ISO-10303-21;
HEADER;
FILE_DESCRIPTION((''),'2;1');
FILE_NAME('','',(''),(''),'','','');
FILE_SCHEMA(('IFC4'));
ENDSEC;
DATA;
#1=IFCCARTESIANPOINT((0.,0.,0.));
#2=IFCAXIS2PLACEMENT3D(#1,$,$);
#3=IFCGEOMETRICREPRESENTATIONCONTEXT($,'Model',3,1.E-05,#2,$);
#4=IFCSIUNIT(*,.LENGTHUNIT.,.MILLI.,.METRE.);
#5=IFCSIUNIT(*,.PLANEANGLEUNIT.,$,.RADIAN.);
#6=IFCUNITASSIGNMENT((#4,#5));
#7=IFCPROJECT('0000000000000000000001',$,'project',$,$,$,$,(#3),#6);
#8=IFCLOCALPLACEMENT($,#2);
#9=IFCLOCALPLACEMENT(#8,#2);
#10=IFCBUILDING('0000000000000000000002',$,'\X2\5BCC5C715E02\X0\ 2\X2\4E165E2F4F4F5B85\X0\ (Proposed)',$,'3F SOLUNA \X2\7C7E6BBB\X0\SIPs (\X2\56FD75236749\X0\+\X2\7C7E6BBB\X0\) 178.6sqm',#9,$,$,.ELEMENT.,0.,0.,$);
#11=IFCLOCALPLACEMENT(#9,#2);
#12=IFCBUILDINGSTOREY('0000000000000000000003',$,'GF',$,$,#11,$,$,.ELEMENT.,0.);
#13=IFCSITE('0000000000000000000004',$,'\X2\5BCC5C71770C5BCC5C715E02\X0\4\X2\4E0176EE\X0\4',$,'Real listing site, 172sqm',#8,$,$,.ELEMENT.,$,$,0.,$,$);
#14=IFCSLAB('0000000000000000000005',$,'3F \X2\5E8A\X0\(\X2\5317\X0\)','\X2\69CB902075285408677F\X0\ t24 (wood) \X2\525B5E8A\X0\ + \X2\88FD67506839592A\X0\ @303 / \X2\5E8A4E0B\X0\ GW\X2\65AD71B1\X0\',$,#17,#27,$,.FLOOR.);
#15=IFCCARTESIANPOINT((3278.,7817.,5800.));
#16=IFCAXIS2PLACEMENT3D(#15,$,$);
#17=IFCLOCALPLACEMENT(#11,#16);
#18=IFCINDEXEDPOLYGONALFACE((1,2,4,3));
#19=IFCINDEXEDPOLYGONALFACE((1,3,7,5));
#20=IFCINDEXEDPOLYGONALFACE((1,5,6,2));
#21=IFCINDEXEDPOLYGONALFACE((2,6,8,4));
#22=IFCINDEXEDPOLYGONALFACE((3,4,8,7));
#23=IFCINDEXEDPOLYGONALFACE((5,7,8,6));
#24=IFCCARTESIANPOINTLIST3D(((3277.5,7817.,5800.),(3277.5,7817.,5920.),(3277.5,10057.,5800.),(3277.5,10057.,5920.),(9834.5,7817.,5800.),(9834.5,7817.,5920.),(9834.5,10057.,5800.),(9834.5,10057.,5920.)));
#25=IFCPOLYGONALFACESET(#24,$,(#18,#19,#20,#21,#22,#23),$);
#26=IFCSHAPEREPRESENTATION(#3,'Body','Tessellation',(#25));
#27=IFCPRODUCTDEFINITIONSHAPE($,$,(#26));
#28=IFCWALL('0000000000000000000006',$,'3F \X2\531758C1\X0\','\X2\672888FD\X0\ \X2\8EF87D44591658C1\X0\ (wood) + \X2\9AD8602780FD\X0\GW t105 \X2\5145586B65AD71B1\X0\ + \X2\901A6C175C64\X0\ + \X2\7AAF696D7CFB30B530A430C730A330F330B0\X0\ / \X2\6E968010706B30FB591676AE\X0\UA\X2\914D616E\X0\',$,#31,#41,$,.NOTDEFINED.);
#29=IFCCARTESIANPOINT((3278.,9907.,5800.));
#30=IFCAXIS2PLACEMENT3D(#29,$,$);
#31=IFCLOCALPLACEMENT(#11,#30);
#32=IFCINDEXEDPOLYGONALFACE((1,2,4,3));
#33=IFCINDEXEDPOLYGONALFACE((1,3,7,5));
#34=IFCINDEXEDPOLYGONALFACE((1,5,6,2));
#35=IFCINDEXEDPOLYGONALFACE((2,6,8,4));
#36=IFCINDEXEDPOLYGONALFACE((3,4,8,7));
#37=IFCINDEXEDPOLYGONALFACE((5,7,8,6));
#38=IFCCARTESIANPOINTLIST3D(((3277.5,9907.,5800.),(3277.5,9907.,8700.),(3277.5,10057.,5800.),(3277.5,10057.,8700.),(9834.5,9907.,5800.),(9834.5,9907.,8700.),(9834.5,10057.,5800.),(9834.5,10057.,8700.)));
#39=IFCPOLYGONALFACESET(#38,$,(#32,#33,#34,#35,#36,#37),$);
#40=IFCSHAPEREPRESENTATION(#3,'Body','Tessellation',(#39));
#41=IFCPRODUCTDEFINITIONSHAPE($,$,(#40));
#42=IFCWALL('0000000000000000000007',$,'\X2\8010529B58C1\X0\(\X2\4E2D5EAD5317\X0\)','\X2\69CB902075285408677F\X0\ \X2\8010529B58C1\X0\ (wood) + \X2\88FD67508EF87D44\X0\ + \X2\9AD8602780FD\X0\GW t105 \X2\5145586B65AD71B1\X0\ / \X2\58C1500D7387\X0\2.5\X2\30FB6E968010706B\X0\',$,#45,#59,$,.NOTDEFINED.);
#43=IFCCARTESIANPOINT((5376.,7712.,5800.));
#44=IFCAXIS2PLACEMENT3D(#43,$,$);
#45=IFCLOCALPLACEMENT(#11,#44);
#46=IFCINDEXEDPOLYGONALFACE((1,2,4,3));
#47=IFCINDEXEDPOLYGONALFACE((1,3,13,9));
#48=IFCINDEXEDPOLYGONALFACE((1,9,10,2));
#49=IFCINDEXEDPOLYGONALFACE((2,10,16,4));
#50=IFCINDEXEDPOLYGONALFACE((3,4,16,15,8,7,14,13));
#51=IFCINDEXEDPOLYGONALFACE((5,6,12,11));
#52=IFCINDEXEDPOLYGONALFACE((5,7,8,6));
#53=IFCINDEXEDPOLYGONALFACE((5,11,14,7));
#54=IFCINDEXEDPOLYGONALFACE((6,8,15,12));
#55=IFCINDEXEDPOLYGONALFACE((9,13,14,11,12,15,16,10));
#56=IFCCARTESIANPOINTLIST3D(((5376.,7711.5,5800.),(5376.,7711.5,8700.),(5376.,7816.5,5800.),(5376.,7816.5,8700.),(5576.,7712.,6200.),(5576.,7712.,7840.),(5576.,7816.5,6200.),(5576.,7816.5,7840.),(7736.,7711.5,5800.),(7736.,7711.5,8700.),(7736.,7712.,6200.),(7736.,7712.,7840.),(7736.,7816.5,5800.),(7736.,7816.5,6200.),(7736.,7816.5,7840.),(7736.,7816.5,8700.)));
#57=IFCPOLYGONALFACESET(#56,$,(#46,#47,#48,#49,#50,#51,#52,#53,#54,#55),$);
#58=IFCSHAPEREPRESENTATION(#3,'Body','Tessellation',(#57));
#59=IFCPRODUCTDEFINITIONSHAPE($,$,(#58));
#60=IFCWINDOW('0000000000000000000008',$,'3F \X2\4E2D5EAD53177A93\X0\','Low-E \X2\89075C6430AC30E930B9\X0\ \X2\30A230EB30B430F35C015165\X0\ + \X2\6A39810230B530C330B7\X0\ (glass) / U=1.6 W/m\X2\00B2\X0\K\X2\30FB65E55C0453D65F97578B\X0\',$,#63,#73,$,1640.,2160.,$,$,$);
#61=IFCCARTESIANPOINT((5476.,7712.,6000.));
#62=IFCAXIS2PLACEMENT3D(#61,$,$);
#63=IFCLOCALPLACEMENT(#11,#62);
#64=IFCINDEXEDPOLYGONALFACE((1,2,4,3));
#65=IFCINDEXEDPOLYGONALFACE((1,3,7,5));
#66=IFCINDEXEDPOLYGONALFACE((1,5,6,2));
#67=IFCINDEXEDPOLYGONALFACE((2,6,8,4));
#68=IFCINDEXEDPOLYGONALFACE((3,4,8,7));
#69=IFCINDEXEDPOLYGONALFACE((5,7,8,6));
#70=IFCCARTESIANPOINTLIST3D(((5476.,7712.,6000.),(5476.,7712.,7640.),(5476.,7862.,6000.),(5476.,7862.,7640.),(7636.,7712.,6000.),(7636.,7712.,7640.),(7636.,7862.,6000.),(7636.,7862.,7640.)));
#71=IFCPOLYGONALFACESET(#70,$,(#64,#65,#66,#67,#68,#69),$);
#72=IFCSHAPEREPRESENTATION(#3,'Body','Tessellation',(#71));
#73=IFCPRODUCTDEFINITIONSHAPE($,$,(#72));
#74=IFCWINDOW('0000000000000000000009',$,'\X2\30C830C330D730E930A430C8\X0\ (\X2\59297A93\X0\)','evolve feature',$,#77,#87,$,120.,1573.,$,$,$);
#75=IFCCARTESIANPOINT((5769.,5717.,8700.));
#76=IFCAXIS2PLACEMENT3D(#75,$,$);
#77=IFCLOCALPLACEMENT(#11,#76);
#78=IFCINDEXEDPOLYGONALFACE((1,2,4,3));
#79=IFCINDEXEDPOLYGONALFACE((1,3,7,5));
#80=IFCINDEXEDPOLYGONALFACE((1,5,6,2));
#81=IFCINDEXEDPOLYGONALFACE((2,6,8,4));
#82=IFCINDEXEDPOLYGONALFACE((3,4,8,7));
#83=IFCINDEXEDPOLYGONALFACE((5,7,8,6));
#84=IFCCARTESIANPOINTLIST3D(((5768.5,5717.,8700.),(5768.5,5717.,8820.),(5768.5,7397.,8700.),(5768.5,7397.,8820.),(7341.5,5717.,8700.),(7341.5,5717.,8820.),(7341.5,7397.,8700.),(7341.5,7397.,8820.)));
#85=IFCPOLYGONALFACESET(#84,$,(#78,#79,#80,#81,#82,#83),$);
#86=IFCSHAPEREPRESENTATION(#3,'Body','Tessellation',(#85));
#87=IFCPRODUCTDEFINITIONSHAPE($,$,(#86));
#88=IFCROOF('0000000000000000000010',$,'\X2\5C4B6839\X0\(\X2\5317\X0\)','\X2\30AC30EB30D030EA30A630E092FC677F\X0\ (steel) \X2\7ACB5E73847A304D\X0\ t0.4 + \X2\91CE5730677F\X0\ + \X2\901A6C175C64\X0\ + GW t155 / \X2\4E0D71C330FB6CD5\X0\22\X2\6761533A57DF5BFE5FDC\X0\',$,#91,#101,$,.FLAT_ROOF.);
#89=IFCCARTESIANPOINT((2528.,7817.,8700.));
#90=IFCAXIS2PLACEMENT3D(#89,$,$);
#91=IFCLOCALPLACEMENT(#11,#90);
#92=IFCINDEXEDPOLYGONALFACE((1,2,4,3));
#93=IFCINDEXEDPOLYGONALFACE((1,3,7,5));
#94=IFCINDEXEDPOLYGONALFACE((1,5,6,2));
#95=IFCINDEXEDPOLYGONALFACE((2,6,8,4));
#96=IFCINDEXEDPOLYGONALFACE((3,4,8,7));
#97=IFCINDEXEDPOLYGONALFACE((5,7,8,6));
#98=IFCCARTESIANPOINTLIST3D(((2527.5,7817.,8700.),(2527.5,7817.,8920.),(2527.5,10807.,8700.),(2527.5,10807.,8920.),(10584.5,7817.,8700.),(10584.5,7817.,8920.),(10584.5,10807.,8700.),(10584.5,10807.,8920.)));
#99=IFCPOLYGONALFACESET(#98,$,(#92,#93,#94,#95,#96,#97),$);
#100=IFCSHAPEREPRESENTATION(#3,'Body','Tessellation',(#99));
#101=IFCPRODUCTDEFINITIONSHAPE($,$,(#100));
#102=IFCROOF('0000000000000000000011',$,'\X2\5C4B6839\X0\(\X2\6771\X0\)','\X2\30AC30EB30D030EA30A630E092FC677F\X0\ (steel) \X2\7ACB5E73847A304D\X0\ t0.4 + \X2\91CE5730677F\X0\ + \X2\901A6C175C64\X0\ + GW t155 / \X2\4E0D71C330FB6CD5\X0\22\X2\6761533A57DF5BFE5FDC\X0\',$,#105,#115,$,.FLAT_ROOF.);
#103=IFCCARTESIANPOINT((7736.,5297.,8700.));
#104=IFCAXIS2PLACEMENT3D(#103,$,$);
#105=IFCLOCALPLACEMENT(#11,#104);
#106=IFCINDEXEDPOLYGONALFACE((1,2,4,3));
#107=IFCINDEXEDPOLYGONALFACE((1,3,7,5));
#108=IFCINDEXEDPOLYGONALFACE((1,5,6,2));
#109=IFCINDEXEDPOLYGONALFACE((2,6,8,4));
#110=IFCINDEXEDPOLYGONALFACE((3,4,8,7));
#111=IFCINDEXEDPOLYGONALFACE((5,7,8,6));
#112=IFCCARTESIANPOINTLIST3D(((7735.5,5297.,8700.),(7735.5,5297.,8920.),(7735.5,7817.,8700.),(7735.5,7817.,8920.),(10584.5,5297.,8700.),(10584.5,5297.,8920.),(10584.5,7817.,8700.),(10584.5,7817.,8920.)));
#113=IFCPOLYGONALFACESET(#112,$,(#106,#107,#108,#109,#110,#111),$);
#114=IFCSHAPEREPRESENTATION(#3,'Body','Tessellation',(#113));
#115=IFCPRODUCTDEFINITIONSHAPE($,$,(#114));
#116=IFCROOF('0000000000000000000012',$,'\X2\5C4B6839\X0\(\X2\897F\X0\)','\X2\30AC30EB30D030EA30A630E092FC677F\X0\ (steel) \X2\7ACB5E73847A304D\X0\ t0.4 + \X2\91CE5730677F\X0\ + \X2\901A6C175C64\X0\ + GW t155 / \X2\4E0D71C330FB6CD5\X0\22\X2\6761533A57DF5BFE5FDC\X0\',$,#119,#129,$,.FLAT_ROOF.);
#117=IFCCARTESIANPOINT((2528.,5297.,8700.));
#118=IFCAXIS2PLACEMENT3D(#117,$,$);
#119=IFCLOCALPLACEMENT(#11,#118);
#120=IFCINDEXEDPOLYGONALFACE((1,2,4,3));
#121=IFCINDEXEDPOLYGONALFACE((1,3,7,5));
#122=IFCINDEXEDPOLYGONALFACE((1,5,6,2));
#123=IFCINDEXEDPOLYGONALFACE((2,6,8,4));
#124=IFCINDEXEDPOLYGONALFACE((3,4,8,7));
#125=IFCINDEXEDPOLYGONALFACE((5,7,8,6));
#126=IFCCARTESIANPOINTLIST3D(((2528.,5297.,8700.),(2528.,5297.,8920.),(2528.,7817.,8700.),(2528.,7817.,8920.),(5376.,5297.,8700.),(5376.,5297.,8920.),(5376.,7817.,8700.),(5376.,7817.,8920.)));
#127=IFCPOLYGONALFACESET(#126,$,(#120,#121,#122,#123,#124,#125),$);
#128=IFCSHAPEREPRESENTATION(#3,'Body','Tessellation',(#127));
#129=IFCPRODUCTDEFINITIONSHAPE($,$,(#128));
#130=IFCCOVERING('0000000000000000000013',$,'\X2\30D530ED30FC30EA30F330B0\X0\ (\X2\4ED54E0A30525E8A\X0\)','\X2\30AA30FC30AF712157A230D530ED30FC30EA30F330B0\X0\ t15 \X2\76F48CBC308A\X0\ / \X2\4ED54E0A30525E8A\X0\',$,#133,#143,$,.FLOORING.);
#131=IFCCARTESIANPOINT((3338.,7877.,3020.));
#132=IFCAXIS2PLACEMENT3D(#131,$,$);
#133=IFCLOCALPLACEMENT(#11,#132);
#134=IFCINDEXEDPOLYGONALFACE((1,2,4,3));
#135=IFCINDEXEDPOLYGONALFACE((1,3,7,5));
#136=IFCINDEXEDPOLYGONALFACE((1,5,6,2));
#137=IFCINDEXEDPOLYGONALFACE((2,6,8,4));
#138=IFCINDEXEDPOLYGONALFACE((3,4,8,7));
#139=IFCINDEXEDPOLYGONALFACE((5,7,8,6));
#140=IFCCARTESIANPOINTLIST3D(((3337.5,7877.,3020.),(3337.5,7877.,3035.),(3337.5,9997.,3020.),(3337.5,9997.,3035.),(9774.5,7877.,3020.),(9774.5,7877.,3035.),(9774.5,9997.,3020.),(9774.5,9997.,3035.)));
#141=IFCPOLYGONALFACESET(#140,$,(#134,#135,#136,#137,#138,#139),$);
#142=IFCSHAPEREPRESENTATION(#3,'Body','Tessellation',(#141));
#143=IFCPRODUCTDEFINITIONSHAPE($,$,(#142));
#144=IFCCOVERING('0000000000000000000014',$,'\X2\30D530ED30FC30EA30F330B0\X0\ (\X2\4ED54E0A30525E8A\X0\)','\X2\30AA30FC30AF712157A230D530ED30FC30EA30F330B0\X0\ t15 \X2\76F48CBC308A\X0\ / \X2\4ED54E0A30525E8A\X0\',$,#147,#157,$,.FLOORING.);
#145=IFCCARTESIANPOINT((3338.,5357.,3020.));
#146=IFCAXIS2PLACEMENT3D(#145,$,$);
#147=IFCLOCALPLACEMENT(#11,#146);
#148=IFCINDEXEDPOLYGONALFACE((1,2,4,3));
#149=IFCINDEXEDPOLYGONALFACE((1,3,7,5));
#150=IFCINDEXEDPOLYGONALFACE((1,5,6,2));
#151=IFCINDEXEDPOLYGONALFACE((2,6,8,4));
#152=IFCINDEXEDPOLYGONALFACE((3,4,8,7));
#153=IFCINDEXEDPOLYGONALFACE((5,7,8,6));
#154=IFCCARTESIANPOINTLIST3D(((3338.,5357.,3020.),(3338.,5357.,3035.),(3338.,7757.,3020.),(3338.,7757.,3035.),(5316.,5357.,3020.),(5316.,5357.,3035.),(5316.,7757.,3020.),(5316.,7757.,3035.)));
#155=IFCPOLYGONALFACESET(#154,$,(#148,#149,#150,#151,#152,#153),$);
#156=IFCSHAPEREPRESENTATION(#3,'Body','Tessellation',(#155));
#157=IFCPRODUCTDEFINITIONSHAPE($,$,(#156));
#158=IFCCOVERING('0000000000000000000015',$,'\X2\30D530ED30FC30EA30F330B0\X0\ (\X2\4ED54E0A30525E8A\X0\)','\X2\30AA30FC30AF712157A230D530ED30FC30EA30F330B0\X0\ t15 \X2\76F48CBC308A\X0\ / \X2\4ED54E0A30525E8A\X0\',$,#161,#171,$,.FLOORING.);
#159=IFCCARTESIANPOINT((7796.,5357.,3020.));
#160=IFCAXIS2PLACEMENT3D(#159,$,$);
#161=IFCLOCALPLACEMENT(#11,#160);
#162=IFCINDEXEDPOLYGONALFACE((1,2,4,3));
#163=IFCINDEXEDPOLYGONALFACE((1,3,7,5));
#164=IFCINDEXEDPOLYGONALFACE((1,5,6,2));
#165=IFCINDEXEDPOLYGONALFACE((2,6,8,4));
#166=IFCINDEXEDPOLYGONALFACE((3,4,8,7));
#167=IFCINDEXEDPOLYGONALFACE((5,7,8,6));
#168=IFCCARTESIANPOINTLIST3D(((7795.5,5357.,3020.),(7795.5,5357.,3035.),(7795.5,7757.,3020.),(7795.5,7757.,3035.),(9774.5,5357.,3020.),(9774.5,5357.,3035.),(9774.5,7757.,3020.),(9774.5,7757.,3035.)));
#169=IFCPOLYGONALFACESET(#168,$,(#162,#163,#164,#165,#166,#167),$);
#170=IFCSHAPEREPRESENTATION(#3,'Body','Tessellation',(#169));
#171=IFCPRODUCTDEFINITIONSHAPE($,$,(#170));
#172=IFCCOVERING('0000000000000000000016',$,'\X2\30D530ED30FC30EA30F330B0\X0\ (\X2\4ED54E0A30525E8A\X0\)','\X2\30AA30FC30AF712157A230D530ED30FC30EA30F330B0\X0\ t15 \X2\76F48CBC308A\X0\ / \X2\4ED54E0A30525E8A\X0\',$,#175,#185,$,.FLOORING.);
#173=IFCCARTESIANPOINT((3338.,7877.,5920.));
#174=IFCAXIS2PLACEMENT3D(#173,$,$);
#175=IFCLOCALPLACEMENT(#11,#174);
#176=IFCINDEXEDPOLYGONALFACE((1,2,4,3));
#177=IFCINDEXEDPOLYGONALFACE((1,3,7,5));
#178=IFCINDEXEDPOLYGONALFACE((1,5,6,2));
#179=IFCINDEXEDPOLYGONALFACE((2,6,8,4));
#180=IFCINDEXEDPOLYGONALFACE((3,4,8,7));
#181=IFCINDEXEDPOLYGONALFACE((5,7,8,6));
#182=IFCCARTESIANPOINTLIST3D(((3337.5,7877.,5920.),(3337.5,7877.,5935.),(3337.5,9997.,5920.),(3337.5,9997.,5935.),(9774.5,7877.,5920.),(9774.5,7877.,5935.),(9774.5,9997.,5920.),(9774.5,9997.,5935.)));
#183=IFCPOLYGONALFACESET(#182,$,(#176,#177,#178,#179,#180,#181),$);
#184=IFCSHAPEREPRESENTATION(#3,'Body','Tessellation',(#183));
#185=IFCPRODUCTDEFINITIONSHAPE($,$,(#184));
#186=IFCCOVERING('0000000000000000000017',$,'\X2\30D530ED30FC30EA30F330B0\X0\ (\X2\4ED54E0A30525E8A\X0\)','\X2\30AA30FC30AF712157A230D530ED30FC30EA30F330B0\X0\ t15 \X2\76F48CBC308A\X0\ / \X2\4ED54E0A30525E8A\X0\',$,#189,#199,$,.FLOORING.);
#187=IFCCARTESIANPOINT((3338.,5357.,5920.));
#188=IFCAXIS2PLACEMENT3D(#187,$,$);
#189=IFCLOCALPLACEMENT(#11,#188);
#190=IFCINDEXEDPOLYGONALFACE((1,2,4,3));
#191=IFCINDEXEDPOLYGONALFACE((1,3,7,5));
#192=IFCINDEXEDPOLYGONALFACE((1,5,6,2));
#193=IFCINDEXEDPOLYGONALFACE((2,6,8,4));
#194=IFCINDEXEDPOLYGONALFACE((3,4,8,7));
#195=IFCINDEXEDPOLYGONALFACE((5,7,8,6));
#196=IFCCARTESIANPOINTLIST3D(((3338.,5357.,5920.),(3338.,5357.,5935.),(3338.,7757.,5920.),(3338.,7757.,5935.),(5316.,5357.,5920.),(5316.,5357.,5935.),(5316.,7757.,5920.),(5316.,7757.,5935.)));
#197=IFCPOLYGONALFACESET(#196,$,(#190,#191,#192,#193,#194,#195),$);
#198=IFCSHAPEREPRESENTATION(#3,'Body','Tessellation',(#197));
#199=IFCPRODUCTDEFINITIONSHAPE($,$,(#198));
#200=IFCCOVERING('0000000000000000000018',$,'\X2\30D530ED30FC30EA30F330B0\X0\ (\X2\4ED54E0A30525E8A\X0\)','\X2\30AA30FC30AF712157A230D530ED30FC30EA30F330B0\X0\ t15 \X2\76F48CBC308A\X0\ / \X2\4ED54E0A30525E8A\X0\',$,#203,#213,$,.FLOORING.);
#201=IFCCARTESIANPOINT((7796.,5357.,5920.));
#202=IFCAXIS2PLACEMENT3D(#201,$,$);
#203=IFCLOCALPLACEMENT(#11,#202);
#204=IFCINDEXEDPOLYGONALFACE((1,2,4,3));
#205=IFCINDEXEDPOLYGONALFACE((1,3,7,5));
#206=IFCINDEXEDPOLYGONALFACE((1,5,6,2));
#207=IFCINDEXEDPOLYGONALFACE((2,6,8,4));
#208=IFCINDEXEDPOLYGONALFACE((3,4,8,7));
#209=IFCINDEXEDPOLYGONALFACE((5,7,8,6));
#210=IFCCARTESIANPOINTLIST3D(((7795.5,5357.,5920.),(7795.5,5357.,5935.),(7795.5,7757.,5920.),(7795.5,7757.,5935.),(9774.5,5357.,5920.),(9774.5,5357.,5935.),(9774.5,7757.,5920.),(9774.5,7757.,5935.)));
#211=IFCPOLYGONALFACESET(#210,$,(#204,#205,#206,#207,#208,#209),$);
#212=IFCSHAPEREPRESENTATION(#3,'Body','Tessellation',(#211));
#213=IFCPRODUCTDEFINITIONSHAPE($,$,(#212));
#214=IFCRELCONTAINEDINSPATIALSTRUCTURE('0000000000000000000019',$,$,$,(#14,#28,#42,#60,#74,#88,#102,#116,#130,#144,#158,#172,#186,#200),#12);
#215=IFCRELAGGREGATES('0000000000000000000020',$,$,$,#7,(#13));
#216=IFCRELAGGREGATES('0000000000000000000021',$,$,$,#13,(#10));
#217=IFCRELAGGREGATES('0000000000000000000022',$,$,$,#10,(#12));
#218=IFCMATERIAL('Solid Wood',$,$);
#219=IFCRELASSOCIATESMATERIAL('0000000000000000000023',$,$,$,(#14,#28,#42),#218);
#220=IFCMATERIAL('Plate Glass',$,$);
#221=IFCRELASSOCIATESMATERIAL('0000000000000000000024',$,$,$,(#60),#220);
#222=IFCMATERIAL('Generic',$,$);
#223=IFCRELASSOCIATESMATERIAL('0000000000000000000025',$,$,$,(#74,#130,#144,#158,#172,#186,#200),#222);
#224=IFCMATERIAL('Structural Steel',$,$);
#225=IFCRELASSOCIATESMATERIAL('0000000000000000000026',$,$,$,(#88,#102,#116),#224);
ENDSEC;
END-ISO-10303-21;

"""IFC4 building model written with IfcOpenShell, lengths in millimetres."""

from ifc_helpers import new_model, si_unit, frame, frame_2d, origin, place, context, project, spatial, rectangle, extrude, material, element, fill, save


model = new_model("IFC4")

# Units and contexts
model_context = context("Model", 3, precision=1e-05, world=origin())
ifc_project = project(units=[si_unit("LENGTHUNIT", "METRE", prefix="MILLI"), si_unit("PLANEANGLEUNIT", "RADIAN")], contexts=[model_context])

# Site, building, storey
site_placement = place(None, origin())
site = spatial("IfcSite", under=ifc_project, at=site_placement, Name="富山県富山市4丁目4", ObjectType="Real listing site, 172sqm", CompositionType="ELEMENT", RefElevation=0.0)
building_placement = place(site_placement, origin())
building = spatial("IfcBuilding", under=site, at=building_placement, Name="富山市 2世帯住宅 (Proposed)", ObjectType="3F SOLUNA 籾殻SIPs (国産杉+籾殻) 178.6sqm", CompositionType="ELEMENT", ElevationOfRefHeight=0.0, ElevationOfTerrain=0.0)
storey_placement = place(building_placement, origin())
storey = spatial("IfcBuildingStorey", under=building, at=storey_placement, Name="GF", CompositionType="ELEMENT", Elevation=0.0)

# Slab
ifc_material_1 = material(Name="Solid Wood")
slab_placement = place(storey_placement, frame((3278.0, 7817.0, 5800.0)))
element("IfcSlab", 1, at=slab_placement, inside=storey, material=ifc_material_1, Name="3F 床(北)", Description="構造用合板 t24 (wood) 剛床 + 製材根太 @303 / 床下 GW断熱", PredefinedType="FLOOR", context=model_context, shape_type="SweptSolid", body=[
    extrude(rectangle(XDim=6557.0, YDim=2240.0, at=frame_2d((3278.0, 1120.0))), frame((3278.0, 7817.0, 5800.0)), (0.0, 0.0, 1.0), 120.0),
])

# Wall
wall_1_placement = place(storey_placement, frame((3278.0, 9907.0, 5800.0)))
element("IfcWall", 2, at=wall_1_placement, inside=storey, material=ifc_material_1, Name="3F 北壁", Description="木製 軸組外壁 (wood) + 高性能GW t105 充填断熱 + 通気層 + 窯業系サイディング / 準耐火・外皮UA配慮", PredefinedType="NOTDEFINED", context=model_context, shape_type="SweptSolid", body=[
    extrude(rectangle(XDim=6557.0, YDim=150.0, at=frame_2d((3278.0, 75.0))), frame((3278.0, 9907.0, 5800.0)), (0.0, 0.0, 1.0), 2900.0),
])

# Wall, opening, window
wall_2_placement = place(storey_placement, frame((5376.0, 7712.0, 5800.0)))
wall_2 = element("IfcWall", 3, at=wall_2_placement, inside=storey, material=ifc_material_1, Name="耐力壁(中庭北)", Description="構造用合板 耐力壁 (wood) + 製材軸組 + 高性能GW t105 充填断熱 / 壁倍率2.5・準耐火", PredefinedType="NOTDEFINED", context=model_context, shape_type="SweptSolid", body=[
    extrude(rectangle(XDim=2360.0, YDim=105.0, at=frame_2d((1180.0, 52.0))), frame((5376.0, 7712.0, 5800.0)), (0.0, 0.0, 1.0), 2900.0),
])
opening_placement = place(storey_placement, frame((5476.0, 7712.0, 6000.0)))
opening = element("IfcOpeningElement", 4, at=opening_placement, cuts=wall_2, PredefinedType="NOTDEFINED", context=model_context, shape_type="SweptSolid", body=[
    extrude(rectangle(XDim=2160.0, YDim=150.0, at=frame_2d((1080.0, 75.0))), frame((5476.0, 7712.0, 6000.0)), (0.0, 0.0, 1.0), 1640.0),
])
ifc_material_2 = material(Name="Plate Glass")
window_1_placement = place(storey_placement, frame((5476.0, 7712.0, 6000.0)))
window_1 = element("IfcWindow", 5, at=window_1_placement, inside=storey, material=ifc_material_2, Name="3F 中庭北窓", Description="Low-E 複層ガラス アルゴン封入 + 樹脂サッシ (glass) / U=1.6 W/m²K・日射取得型", OverallHeight=1640.0, OverallWidth=2160.0, context=model_context, shape_type="SweptSolid", body=[
    extrude(rectangle(XDim=2160.0, YDim=150.0, at=frame_2d((1080.0, 75.0))), frame((5476.0, 7712.0, 6000.0)), (0.0, 0.0, 1.0), 1640.0),
])
fill(opening, window_1)

# Window
ifc_material_3 = material(Name="Generic")
window_2_placement = place(storey_placement, frame((5769.0, 5717.0, 8700.0)))
element("IfcWindow", 6, at=window_2_placement, inside=storey, material=ifc_material_3, Name="トップライト (天窓)", Description="evolve feature", OverallHeight=120.0, OverallWidth=1573.0, context=model_context, shape_type="SweptSolid", body=[
    extrude(rectangle(XDim=1573.0, YDim=1680.0, at=frame_2d((786.0, 840.0))), frame((5769.0, 5717.0, 8700.0)), (0.0, 0.0, 1.0), 120.0),
])

# Roofs
ifc_material_4 = material(Name="Structural Steel")
roof_1_placement = place(storey_placement, frame((2528.0, 7817.0, 8700.0)))
element("IfcRoof", 7, at=roof_1_placement, inside=storey, material=ifc_material_4, Name="屋根(北)", Description="ガルバリウム鋼板 (steel) 立平葺き t0.4 + 野地板 + 通気層 + GW t155 / 不燃・法22条区域対応", PredefinedType="FLAT_ROOF", context=model_context, shape_type="SweptSolid", body=[
    extrude(rectangle(XDim=8057.0, YDim=2990.0, at=frame_2d((4028.0, 1495.0))), frame((2528.0, 7817.0, 8700.0)), (0.0, 0.0, 1.0), 220.0),
])
roof_2_placement = place(storey_placement, frame((7736.0, 5297.0, 8700.0)))
element("IfcRoof", 8, at=roof_2_placement, inside=storey, material=ifc_material_4, Name="屋根(東)", Description="ガルバリウム鋼板 (steel) 立平葺き t0.4 + 野地板 + 通気層 + GW t155 / 不燃・法22条区域対応", PredefinedType="FLAT_ROOF", context=model_context, shape_type="SweptSolid", body=[
    extrude(rectangle(XDim=2849.0, YDim=2520.0, at=frame_2d((1424.0, 1260.0))), frame((7736.0, 5297.0, 8700.0)), (0.0, 0.0, 1.0), 220.0),
])
roof_3_placement = place(storey_placement, frame((2528.0, 5297.0, 8700.0)))
element("IfcRoof", 9, at=roof_3_placement, inside=storey, material=ifc_material_4, Name="屋根(西)", Description="ガルバリウム鋼板 (steel) 立平葺き t0.4 + 野地板 + 通気層 + GW t155 / 不燃・法22条区域対応", PredefinedType="FLAT_ROOF", context=model_context, shape_type="SweptSolid", body=[
    extrude(rectangle(XDim=2848.0, YDim=2520.0, at=frame_2d((1424.0, 1260.0))), frame((2528.0, 5297.0, 8700.0)), (0.0, 0.0, 1.0), 220.0),
])

# Coverings
covering_1_placement = place(storey_placement, frame((3338.0, 7877.0, 3020.0)))
element("IfcCovering", 10, at=covering_1_placement, inside=storey, material=ifc_material_3, Name="フローリング (仕上げ床)", Description="オーク無垢フローリング t15 直貼り / 仕上げ床", PredefinedType="FLOORING", context=model_context, shape_type="SweptSolid", body=[
    extrude(rectangle(XDim=6437.0, YDim=2120.0, at=frame_2d((3218.0, 1060.0))), frame((3338.0, 7877.0, 3020.0)), (0.0, 0.0, 1.0), 15.0),
])
covering_2_placement = place(storey_placement, frame((3338.0, 5357.0, 3020.0)))
element("IfcCovering", 11, at=covering_2_placement, inside=storey, material=ifc_material_3, Name="フローリング (仕上げ床)", Description="オーク無垢フローリング t15 直貼り / 仕上げ床", PredefinedType="FLOORING", context=model_context, shape_type="SweptSolid", body=[
    extrude(rectangle(XDim=1978.0, YDim=2400.0, at=frame_2d((989.0, 1200.0))), frame((3338.0, 5357.0, 3020.0)), (0.0, 0.0, 1.0), 15.0),
])
covering_3_placement = place(storey_placement, frame((7796.0, 5357.0, 3020.0)))
element("IfcCovering", 12, at=covering_3_placement, inside=storey, material=ifc_material_3, Name="フローリング (仕上げ床)", Description="オーク無垢フローリング t15 直貼り / 仕上げ床", PredefinedType="FLOORING", context=model_context, shape_type="SweptSolid", body=[
    extrude(rectangle(XDim=1979.0, YDim=2400.0, at=frame_2d((989.0, 1200.0))), frame((7796.0, 5357.0, 3020.0)), (0.0, 0.0, 1.0), 15.0),
])
covering_4_placement = place(storey_placement, frame((3338.0, 7877.0, 5920.0)))
element("IfcCovering", 13, at=covering_4_placement, inside=storey, material=ifc_material_3, Name="フローリング (仕上げ床)", Description="オーク無垢フローリング t15 直貼り / 仕上げ床", PredefinedType="FLOORING", context=model_context, shape_type="SweptSolid", body=[
    extrude(rectangle(XDim=6437.0, YDim=2120.0, at=frame_2d((3218.0, 1060.0))), frame((3338.0, 7877.0, 5920.0)), (0.0, 0.0, 1.0), 15.0),
])
covering_5_placement = place(storey_placement, frame((3338.0, 5357.0, 5920.0)))
element("IfcCovering", 14, at=covering_5_placement, inside=storey, material=ifc_material_3, Name="フローリング (仕上げ床)", Description="オーク無垢フローリング t15 直貼り / 仕上げ床", PredefinedType="FLOORING", context=model_context, shape_type="SweptSolid", body=[
    extrude(rectangle(XDim=1978.0, YDim=2400.0, at=frame_2d((989.0, 1200.0))), frame((3338.0, 5357.0, 5920.0)), (0.0, 0.0, 1.0), 15.0),
])
covering_6_placement = place(storey_placement, frame((7796.0, 5357.0, 5920.0)))
element("IfcCovering", 15, at=covering_6_placement, inside=storey, material=ifc_material_3, Name="フローリング (仕上げ床)", Description="オーク無垢フローリング t15 直貼り / 仕上げ床", PredefinedType="FLOORING", context=model_context, shape_type="SweptSolid", body=[
    extrude(rectangle(XDim=1979.0, YDim=2400.0, at=frame_2d((989.0, 1200.0))), frame((7796.0, 5357.0, 5920.0)), (0.0, 0.0, 1.0), 15.0),
])

save(model, "model.ifc")
